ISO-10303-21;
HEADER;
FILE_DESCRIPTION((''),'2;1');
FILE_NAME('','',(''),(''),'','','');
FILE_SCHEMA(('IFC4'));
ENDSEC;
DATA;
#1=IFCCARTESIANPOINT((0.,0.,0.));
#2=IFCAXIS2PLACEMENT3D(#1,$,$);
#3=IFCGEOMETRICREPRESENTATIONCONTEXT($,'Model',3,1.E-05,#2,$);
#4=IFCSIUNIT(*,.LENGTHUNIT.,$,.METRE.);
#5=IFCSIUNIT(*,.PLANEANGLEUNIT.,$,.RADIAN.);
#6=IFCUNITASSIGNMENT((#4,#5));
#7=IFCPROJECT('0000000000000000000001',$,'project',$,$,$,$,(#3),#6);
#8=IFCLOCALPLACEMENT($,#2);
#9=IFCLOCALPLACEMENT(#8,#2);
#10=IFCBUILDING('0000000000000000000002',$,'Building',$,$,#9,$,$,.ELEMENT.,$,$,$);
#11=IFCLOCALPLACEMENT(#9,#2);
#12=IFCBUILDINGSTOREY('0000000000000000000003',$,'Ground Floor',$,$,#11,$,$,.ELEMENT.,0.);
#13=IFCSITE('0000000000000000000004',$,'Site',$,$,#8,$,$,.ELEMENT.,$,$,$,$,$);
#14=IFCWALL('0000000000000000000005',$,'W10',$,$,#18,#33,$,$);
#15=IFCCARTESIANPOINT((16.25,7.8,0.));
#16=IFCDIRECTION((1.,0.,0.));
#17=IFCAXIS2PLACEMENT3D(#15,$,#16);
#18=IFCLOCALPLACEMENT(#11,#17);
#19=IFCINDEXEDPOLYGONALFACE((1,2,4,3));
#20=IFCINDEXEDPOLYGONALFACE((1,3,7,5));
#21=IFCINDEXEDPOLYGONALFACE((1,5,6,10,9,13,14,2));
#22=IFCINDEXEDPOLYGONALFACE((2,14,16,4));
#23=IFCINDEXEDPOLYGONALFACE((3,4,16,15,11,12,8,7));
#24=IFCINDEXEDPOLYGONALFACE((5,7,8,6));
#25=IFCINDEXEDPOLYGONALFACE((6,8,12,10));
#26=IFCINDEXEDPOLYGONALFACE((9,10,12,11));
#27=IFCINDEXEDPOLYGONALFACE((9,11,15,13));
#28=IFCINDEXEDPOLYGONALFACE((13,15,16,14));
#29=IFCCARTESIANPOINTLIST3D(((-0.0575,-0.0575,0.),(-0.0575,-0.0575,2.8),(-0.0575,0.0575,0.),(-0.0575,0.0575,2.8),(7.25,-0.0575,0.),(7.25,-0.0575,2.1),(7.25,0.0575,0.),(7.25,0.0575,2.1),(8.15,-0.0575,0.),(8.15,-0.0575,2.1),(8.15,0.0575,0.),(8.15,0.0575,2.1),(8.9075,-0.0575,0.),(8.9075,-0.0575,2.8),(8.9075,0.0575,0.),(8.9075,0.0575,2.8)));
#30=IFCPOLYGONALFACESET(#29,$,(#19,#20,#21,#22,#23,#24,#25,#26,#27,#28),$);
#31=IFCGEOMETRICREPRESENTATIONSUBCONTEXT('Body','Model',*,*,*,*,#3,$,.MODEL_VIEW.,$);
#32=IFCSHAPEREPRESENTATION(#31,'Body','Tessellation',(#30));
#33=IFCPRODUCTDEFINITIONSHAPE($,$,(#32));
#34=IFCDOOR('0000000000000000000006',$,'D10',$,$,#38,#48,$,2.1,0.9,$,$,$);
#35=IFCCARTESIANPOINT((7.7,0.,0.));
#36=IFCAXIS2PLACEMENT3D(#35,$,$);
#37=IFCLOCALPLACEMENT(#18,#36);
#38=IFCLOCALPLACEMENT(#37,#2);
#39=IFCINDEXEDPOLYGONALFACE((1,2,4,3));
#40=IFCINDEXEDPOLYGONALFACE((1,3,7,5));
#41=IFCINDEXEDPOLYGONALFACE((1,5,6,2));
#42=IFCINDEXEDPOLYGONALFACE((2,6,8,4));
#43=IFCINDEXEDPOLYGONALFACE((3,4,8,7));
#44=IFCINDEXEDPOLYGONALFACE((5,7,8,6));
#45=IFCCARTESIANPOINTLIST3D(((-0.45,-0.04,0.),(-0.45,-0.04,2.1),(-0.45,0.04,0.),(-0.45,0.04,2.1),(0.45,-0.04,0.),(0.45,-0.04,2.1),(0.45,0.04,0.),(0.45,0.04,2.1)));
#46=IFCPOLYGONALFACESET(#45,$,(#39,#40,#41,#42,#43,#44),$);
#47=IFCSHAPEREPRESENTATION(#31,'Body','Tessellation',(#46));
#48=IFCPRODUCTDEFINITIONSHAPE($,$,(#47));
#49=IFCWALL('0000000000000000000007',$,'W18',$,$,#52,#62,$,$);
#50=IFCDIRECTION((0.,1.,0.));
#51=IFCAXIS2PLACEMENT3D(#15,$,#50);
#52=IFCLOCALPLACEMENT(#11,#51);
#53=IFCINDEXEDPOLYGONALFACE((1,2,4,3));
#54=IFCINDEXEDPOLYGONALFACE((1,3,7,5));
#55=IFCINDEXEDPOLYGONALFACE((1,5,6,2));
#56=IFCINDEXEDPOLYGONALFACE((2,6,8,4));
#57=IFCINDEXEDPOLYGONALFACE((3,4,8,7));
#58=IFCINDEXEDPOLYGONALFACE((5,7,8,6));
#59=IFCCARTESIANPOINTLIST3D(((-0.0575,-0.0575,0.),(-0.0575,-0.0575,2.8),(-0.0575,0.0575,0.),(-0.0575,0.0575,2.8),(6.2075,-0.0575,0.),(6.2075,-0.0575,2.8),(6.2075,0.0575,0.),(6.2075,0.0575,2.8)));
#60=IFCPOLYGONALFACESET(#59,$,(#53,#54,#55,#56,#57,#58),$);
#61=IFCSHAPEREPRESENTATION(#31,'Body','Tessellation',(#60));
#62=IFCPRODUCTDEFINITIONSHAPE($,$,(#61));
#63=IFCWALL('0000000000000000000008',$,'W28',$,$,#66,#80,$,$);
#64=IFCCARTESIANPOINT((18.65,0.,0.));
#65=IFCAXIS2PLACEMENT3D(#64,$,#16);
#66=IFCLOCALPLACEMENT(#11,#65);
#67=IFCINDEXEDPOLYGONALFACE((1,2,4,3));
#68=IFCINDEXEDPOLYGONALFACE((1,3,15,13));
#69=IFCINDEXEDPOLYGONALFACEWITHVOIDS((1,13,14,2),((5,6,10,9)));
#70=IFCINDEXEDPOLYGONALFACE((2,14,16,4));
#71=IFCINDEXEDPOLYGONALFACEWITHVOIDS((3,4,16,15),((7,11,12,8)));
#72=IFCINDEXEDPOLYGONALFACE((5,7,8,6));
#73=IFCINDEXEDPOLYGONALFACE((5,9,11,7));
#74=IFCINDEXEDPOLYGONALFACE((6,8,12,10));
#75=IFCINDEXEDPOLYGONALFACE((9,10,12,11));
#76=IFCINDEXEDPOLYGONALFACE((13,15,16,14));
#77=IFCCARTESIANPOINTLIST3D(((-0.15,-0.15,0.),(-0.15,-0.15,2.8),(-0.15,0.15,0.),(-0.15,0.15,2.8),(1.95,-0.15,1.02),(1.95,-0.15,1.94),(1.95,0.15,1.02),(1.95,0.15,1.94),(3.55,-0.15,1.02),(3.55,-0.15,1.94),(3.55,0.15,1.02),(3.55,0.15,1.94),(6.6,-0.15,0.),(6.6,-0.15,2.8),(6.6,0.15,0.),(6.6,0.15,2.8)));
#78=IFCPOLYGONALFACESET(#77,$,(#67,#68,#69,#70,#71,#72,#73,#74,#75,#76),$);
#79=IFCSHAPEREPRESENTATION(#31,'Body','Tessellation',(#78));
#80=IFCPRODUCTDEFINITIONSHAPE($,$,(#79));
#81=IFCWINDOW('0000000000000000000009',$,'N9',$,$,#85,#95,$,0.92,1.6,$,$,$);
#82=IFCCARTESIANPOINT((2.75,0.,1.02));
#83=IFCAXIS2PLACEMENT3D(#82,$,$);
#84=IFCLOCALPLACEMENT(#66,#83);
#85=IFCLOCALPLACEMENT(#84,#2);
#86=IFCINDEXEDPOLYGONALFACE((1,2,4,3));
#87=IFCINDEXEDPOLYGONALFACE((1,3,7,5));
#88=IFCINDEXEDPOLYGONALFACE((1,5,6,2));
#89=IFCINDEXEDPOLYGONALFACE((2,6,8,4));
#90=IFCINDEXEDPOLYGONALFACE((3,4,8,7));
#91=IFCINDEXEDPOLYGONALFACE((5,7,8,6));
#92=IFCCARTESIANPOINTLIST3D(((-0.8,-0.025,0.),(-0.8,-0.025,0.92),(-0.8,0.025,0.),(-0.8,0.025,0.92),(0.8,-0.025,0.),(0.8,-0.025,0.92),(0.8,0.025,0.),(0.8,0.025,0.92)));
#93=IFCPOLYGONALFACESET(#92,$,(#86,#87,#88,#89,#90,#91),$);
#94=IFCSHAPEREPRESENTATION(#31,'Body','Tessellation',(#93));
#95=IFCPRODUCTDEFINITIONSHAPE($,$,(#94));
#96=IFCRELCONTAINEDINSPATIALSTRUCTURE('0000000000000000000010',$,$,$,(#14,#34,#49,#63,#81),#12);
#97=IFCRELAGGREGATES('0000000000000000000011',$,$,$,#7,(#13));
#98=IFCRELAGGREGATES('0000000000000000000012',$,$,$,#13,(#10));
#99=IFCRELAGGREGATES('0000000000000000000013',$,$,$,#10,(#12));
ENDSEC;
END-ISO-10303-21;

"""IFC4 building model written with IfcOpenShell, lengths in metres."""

from ifc_helpers import new_model, si_unit, frame, frame_2d, origin, origin_2d, place, context, subcontext, project, spatial, rectangle, extrude, element, fill, save


model = new_model("IFC4")

# Units and contexts
model_context = context("Model", 3, precision=1e-05, world=origin())
body_context = subcontext(model_context, "Body", "Model", "MODEL_VIEW")
ifc_project = project(units=[si_unit("LENGTHUNIT", "METRE"), si_unit("PLANEANGLEUNIT", "RADIAN")], contexts=[model_context])

# Site, building, storey
site_placement = place(None, origin())
site = spatial("IfcSite", under=ifc_project, at=site_placement, Name="Site", CompositionType="ELEMENT")
building_placement = place(site_placement, origin())
building = spatial("IfcBuilding", under=site, at=building_placement, Name="Building", CompositionType="ELEMENT")
storey_placement = place(building_placement, origin())
storey = spatial("IfcBuildingStorey", under=building, at=storey_placement, Name="Ground Floor", CompositionType="ELEMENT", Elevation=0.0)

# Wall, opening, door
wall_1_placement = place(storey_placement, frame((16.25, 7.8, 0.0), x_axis=(1.0, 0.0, 0.0)))
wall_1 = element("IfcWall", 1, at=wall_1_placement, inside=storey, Name="W10", context=body_context, shape_type="SweptSolid", body=[
    extrude(rectangle(XDim=8.965, YDim=0.115, at=frame_2d((4.425, 0.0))), origin(), (0.0, 0.0, 1.0), 2.8),
])
opening_1_placement = place(wall_1_placement, frame((7.7, 0.0, 0.0)))
opening_1 = element("IfcOpeningElement", 2, at=opening_1_placement, cuts=wall_1, context=body_context, shape_type="SweptSolid", body=[
    extrude(rectangle(XDim=0.9, YDim=0.215, at=origin_2d()), origin(), (0.0, 0.0, 1.0), 2.1),
])
door_1_placement = place(opening_1_placement, origin())
door_1 = element("IfcDoor", 3, at=door_1_placement, inside=storey, Name="D10", OverallHeight=2.1, OverallWidth=0.9, context=body_context, shape_type="SweptSolid", body=[
    extrude(rectangle(XDim=0.9, YDim=0.08, at=origin_2d()), origin(), (0.0, 0.0, 1.0), 2.1),
])
fill(opening_1, door_1)

# Wall
wall_2_placement = place(storey_placement, frame((16.25, 7.8, 0.0), x_axis=(0.0, 1.0, 0.0)))
element("IfcWall", 4, at=wall_2_placement, inside=storey, Name="W18", context=body_context, shape_type="SweptSolid", body=[
    extrude(rectangle(XDim=6.265, YDim=0.115, at=frame_2d((3.075, 0.0))), origin(), (0.0, 0.0, 1.0), 2.8),
])

# Wall, opening, window
wall_3_placement = place(storey_placement, frame((18.65, 0.0, 0.0), x_axis=(1.0, 0.0, 0.0)))
wall_3 = element("IfcWall", 5, at=wall_3_placement, inside=storey, Name="W28", context=body_context, shape_type="SweptSolid", body=[
    extrude(rectangle(XDim=6.75, YDim=0.3, at=frame_2d((3.225, 0.0))), origin(), (0.0, 0.0, 1.0), 2.8),
])
opening_2_placement = place(wall_3_placement, frame((2.75, 0.0, 1.02)))
opening_2 = element("IfcOpeningElement", 6, at=opening_2_placement, cuts=wall_3, context=body_context, shape_type="SweptSolid", body=[
    extrude(rectangle(XDim=1.6, YDim=0.4, at=origin_2d()), origin(), (0.0, 0.0, 1.0), 0.92),
])
window_1_placement = place(opening_2_placement, origin())
window_1 = element("IfcWindow", 7, at=window_1_placement, inside=storey, Name="N9", OverallHeight=0.92, OverallWidth=1.6, context=body_context, shape_type="SweptSolid", body=[
    extrude(rectangle(XDim=1.6, YDim=0.05, at=origin_2d()), origin(), (0.0, 0.0, 1.0), 0.92),
])
fill(opening_2, window_1)

save(model, "model.ifc")
